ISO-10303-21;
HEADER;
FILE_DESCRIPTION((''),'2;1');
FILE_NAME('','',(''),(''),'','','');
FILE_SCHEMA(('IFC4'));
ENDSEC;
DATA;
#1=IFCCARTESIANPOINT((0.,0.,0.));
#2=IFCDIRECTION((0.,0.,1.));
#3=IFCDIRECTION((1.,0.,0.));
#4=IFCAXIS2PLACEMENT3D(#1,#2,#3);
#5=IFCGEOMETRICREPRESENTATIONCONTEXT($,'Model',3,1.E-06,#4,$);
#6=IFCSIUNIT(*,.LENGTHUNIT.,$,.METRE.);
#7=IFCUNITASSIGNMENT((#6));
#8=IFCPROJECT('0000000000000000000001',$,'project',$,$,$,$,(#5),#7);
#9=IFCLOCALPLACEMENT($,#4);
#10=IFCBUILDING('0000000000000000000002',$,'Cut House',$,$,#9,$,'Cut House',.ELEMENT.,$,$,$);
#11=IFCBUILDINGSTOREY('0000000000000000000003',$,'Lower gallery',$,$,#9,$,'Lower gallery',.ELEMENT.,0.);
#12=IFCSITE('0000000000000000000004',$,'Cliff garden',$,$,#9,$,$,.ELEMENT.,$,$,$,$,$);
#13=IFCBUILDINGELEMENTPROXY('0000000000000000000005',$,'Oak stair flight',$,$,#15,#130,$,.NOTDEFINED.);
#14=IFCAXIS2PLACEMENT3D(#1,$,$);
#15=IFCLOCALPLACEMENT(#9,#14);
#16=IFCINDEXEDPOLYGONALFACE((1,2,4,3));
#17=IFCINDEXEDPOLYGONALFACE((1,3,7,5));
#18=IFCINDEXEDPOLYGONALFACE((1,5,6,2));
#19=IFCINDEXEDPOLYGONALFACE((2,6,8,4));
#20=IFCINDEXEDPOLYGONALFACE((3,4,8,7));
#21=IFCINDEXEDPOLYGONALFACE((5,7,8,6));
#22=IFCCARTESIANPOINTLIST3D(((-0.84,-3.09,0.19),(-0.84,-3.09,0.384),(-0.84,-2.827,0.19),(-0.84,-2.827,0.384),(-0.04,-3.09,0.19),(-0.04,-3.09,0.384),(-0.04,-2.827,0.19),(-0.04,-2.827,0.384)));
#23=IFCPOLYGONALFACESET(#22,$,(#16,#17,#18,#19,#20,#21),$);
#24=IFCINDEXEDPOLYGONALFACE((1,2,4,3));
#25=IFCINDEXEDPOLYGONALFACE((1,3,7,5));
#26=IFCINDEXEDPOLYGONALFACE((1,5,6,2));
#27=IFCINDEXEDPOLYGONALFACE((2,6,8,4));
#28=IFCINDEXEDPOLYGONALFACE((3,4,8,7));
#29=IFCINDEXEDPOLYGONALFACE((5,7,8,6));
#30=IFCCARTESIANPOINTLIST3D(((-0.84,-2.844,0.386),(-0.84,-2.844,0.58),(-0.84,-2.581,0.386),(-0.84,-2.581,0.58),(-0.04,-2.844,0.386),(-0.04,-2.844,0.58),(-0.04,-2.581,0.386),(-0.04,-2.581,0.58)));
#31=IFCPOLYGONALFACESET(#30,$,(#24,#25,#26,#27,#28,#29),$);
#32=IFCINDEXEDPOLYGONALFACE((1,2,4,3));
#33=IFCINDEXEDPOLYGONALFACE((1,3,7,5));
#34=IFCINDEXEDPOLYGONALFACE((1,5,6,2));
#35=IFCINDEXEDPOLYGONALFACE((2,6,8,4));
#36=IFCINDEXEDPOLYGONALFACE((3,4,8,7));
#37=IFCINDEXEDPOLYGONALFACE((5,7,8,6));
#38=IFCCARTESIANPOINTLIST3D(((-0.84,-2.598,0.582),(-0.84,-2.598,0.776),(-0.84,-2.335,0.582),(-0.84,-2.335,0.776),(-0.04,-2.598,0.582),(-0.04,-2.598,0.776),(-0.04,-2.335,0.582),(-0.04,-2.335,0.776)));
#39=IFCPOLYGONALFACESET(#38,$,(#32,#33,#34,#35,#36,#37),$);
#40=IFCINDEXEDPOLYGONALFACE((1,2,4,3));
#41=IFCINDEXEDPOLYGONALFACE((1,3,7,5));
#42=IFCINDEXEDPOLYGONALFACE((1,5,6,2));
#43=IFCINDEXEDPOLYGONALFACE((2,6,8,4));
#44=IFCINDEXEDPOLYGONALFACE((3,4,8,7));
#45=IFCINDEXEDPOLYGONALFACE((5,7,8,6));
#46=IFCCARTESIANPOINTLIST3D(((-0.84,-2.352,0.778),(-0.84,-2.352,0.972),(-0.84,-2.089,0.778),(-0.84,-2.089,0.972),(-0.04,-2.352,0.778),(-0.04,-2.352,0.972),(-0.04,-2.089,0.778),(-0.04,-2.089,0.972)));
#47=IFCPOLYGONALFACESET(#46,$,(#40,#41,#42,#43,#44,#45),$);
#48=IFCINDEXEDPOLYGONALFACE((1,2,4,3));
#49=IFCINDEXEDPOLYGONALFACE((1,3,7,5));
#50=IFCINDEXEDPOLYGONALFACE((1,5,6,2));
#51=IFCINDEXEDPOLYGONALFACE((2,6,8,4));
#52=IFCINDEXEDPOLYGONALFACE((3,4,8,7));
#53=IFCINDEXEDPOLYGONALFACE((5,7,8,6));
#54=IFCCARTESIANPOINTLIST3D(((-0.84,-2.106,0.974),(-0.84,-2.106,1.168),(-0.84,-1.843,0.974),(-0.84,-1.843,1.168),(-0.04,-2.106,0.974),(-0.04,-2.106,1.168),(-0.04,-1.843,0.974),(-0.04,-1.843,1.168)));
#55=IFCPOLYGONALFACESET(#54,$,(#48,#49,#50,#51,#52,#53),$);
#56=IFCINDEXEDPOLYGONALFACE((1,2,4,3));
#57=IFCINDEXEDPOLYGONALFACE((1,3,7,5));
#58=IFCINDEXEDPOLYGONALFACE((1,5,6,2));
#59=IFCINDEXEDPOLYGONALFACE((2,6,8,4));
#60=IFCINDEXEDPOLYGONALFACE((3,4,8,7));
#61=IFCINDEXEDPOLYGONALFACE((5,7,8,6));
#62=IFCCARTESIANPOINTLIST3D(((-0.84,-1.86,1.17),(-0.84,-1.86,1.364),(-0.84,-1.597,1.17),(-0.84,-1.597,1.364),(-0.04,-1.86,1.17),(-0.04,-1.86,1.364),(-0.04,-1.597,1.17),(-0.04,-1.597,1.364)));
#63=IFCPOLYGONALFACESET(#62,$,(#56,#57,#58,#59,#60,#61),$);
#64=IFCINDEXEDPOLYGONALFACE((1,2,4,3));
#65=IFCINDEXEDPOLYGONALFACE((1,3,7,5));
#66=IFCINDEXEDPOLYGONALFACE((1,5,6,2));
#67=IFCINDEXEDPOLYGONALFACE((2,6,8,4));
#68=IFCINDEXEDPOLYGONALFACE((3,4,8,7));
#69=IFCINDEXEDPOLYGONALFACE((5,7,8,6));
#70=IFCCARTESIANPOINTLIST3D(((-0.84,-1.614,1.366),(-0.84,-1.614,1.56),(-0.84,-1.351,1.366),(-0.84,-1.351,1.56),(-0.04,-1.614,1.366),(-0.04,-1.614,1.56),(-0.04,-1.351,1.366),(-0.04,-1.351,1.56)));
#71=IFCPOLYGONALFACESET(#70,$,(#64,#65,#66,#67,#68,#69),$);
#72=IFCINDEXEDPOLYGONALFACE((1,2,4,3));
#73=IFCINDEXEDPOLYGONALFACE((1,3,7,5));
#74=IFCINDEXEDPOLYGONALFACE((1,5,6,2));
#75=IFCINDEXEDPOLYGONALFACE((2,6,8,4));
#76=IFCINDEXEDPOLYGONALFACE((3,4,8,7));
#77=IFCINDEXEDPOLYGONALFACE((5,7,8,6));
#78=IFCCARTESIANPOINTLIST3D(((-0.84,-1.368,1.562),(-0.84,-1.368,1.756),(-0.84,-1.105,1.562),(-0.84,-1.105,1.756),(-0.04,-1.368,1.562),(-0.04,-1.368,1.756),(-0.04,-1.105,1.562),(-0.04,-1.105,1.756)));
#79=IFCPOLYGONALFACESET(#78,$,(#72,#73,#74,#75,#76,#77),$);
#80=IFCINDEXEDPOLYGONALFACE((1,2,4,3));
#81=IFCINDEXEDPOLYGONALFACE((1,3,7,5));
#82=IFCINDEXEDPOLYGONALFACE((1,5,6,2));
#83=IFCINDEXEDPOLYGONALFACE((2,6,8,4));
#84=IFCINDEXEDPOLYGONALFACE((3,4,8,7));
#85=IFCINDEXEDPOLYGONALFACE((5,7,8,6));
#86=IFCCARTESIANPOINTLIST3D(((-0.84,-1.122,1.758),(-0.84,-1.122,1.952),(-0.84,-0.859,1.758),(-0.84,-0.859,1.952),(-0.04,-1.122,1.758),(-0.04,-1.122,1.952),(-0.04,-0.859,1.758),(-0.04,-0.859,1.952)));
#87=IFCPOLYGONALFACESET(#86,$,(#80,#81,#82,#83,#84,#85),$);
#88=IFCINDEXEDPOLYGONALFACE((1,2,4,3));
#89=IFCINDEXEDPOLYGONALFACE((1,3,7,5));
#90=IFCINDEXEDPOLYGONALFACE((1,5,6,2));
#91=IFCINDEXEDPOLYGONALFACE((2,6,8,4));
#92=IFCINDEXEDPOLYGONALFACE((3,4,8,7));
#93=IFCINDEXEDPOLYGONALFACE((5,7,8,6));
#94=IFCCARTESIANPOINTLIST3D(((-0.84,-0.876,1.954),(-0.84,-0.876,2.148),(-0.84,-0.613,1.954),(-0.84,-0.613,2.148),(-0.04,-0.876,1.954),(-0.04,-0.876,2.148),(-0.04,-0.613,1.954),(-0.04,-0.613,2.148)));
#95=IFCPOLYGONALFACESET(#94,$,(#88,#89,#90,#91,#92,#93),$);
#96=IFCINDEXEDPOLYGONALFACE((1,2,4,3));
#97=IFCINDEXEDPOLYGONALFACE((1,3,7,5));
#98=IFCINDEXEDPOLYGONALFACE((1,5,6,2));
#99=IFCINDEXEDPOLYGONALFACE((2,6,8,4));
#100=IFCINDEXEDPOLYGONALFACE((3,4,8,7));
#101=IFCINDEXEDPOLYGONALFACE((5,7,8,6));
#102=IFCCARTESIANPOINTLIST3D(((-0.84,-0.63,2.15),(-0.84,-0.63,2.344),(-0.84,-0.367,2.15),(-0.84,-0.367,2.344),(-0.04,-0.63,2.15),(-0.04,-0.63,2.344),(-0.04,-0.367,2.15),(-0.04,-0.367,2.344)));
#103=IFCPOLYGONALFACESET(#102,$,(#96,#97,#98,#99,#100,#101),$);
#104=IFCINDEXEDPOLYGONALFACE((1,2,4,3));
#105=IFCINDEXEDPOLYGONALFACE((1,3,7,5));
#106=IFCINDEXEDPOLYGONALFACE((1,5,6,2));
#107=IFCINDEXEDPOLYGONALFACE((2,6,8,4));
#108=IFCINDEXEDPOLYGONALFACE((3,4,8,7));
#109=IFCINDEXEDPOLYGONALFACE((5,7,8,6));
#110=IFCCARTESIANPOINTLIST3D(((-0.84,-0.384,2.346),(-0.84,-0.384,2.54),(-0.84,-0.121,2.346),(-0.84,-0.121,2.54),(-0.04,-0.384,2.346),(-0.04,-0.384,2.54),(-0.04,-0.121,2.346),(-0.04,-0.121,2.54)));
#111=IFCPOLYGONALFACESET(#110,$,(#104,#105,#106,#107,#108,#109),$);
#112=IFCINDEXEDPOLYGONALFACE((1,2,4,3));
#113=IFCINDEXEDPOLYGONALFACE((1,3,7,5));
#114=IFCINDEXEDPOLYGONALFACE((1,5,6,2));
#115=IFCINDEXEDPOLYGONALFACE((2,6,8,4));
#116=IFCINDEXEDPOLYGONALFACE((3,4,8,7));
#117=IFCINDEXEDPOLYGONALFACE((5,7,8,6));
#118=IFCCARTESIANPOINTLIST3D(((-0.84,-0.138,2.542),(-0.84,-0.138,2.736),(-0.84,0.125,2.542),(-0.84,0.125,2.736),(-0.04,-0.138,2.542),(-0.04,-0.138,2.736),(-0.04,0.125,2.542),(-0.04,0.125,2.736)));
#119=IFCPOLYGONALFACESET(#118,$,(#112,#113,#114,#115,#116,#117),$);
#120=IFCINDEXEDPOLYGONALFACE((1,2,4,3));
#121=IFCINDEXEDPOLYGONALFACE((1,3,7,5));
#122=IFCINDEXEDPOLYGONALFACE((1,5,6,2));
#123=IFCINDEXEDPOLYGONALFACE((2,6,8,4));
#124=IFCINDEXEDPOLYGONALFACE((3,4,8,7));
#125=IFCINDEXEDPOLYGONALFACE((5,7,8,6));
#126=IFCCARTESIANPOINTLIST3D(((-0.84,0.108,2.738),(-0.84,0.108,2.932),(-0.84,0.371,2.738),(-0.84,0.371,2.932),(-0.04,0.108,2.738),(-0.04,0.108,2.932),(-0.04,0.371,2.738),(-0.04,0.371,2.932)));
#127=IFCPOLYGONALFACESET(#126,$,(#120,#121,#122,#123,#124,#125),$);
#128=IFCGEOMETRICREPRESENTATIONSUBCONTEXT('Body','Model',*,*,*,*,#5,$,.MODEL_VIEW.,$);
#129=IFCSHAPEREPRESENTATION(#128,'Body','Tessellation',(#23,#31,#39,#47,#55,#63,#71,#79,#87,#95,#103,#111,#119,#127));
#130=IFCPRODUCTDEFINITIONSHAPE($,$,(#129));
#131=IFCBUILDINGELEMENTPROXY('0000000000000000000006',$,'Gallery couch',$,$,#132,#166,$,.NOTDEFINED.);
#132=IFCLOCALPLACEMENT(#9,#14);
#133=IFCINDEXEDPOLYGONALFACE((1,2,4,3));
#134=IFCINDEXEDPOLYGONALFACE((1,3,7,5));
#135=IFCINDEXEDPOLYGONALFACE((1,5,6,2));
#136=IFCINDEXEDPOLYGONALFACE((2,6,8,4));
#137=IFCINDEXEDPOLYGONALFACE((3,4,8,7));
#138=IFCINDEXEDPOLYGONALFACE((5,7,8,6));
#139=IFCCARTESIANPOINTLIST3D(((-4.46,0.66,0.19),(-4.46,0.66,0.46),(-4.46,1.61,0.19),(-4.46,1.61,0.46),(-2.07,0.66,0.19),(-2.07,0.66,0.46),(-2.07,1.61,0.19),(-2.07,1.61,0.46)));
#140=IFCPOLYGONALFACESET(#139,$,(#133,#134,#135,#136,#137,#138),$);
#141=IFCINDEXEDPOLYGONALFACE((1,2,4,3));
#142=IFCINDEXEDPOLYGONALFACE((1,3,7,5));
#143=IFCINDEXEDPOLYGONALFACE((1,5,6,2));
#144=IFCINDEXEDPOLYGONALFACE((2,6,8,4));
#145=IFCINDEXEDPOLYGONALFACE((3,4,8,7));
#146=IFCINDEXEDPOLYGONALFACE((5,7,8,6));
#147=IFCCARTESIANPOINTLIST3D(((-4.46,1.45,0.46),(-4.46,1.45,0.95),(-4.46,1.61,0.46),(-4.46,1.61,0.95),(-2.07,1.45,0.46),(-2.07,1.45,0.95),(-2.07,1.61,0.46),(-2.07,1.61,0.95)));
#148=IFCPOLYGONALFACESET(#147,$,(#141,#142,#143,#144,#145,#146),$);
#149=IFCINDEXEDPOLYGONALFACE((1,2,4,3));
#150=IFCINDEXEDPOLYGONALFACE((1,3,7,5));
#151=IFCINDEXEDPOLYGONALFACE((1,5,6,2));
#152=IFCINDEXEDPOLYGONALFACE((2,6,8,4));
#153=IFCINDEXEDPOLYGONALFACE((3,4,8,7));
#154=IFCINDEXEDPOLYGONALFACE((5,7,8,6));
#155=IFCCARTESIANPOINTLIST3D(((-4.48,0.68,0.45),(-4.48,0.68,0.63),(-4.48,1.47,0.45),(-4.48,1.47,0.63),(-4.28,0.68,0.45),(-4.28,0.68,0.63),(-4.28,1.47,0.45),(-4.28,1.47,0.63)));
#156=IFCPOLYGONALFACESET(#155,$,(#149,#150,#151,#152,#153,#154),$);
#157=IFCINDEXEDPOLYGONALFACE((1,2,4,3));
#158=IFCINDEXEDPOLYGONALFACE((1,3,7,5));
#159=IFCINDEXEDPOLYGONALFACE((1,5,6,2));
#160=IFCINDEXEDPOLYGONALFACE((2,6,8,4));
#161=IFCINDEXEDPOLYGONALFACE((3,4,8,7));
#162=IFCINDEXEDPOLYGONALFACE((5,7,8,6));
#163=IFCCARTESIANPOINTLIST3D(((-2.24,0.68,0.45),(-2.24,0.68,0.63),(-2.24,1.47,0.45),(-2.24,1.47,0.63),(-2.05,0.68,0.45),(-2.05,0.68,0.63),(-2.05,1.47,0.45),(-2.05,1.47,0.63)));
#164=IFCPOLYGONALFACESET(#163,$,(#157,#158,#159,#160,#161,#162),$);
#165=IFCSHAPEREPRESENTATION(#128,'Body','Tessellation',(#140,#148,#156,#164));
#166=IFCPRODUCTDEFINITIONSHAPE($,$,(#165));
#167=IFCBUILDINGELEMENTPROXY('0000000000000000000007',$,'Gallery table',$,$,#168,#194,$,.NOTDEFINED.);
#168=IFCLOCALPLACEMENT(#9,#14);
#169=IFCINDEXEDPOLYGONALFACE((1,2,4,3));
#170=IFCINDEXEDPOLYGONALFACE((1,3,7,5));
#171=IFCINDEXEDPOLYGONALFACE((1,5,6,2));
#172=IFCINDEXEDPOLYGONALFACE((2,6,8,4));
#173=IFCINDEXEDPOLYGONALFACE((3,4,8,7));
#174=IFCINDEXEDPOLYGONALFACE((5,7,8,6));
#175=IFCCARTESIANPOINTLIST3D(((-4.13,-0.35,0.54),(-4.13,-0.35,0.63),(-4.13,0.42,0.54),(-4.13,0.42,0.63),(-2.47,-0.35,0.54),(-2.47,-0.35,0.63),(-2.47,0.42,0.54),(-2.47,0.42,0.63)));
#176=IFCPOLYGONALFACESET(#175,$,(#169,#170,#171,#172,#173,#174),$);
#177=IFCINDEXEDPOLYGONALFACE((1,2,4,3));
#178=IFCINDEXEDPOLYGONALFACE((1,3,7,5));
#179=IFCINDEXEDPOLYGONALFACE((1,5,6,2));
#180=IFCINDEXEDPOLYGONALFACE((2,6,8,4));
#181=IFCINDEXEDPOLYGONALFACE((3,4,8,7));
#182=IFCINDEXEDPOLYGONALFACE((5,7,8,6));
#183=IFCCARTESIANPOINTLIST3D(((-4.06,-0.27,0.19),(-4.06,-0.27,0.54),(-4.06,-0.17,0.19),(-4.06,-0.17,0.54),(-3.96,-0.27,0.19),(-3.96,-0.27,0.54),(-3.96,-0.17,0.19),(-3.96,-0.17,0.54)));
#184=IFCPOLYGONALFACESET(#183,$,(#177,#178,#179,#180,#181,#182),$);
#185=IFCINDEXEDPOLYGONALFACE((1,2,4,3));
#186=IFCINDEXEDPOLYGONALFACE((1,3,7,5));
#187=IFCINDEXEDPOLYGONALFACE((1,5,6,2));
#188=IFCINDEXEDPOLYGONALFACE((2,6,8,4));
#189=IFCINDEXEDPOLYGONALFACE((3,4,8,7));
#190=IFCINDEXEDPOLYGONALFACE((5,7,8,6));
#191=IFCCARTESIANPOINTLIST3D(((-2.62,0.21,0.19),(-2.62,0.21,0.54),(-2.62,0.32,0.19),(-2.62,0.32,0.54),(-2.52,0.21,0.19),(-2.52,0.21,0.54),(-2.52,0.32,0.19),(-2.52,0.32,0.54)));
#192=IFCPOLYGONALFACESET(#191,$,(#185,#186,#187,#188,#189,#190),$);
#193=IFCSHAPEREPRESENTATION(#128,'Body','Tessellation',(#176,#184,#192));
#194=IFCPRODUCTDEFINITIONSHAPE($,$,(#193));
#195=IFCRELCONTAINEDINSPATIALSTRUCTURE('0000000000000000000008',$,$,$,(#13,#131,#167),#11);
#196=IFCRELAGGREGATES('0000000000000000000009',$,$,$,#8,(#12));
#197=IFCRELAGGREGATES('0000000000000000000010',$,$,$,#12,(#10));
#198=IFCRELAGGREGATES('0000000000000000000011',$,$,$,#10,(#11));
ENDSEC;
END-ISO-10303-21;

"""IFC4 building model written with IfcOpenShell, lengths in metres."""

from ifc_helpers import new_model, si_unit, frame, origin_with_axes, place, context, subcontext, project, spatial, polyline, outline, extrude, element, save


model = new_model("IFC4")

# Units and contexts
model_context = context("Model", 3, precision=1e-06, world=origin_with_axes())
body_context = subcontext(model_context, "Body", "Model", "MODEL_VIEW")
ifc_project = project(units=[si_unit("LENGTHUNIT", "METRE")], contexts=[model_context])

# Site, building, storey
placement = place(None, origin_with_axes())
site = spatial("IfcSite", under=ifc_project, at=placement, Name="Cliff garden", CompositionType="ELEMENT")
building = spatial("IfcBuilding", under=site, at=placement, Name="Cut House", LongName="Cut House", CompositionType="ELEMENT")
storey = spatial("IfcBuildingStorey", under=building, at=placement, Name="Lower gallery", LongName="Lower gallery", CompositionType="ELEMENT", Elevation=0.0)

# Building element proxies
element("IfcBuildingElementProxy", 1, at=placement, inside=storey, Name="Oak stair flight", PredefinedType="NOTDEFINED", context=body_context, shape_type="SweptSolid", body=[
    extrude(outline(polyline([(0.0, 0.0), (0.8, 0.0), (0.8, 0.263), (0.0, 0.263), (0.0, 0.0)])), frame((-0.84, -3.09, 0.19), z_axis=(0.0, 0.0, 1.0), x_axis=(1.0, 0.0, 0.0)), (0.0, 0.0, 1.0), 0.194),
    extrude(outline(polyline([(0.0, 0.0), (0.8, 0.0), (0.8, 0.263), (0.0, 0.263), (0.0, 0.0)])), frame((-0.84, -2.844, 0.386), z_axis=(0.0, 0.0, 1.0), x_axis=(1.0, 0.0, 0.0)), (0.0, 0.0, 1.0), 0.194),
    extrude(outline(polyline([(0.0, 0.0), (0.8, 0.0), (0.8, 0.263), (0.0, 0.263), (0.0, 0.0)])), frame((-0.84, -2.598, 0.582), z_axis=(0.0, 0.0, 1.0), x_axis=(1.0, 0.0, 0.0)), (0.0, 0.0, 1.0), 0.194),
    extrude(outline(polyline([(0.0, 0.0), (0.8, 0.0), (0.8, 0.263), (0.0, 0.263), (0.0, 0.0)])), frame((-0.84, -2.352, 0.778), z_axis=(0.0, 0.0, 1.0), x_axis=(1.0, 0.0, 0.0)), (0.0, 0.0, 1.0), 0.194),
    extrude(outline(polyline([(0.0, 0.0), (0.8, 0.0), (0.8, 0.263), (0.0, 0.263), (0.0, 0.0)])), frame((-0.84, -2.106, 0.974), z_axis=(0.0, 0.0, 1.0), x_axis=(1.0, 0.0, 0.0)), (0.0, 0.0, 1.0), 0.194),
    extrude(outline(polyline([(0.0, 0.0), (0.8, 0.0), (0.8, 0.263), (0.0, 0.263), (0.0, 0.0)])), frame((-0.84, -1.86, 1.17), z_axis=(0.0, 0.0, 1.0), x_axis=(1.0, 0.0, 0.0)), (0.0, 0.0, 1.0), 0.194),
    extrude(outline(polyline([(0.0, 0.0), (0.8, 0.0), (0.8, 0.263), (0.0, 0.263), (0.0, 0.0)])), frame((-0.84, -1.614, 1.366), z_axis=(0.0, 0.0, 1.0), x_axis=(1.0, 0.0, 0.0)), (0.0, 0.0, 1.0), 0.194),
    extrude(outline(polyline([(0.0, 0.0), (0.8, 0.0), (0.8, 0.263), (0.0, 0.263), (0.0, 0.0)])), frame((-0.84, -1.368, 1.562), z_axis=(0.0, 0.0, 1.0), x_axis=(1.0, 0.0, 0.0)), (0.0, 0.0, 1.0), 0.194),
    extrude(outline(polyline([(0.0, 0.0), (0.8, 0.0), (0.8, 0.263), (0.0, 0.263), (0.0, 0.0)])), frame((-0.84, -1.122, 1.758), z_axis=(0.0, 0.0, 1.0), x_axis=(1.0, 0.0, 0.0)), (0.0, 0.0, 1.0), 0.194),
    extrude(outline(polyline([(0.0, 0.0), (0.8, 0.0), (0.8, 0.263), (0.0, 0.263), (0.0, 0.0)])), frame((-0.84, -0.876, 1.954), z_axis=(0.0, 0.0, 1.0), x_axis=(1.0, 0.0, 0.0)), (0.0, 0.0, 1.0), 0.194),
    extrude(outline(polyline([(0.0, 0.0), (0.8, 0.0), (0.8, 0.263), (0.0, 0.263), (0.0, 0.0)])), frame((-0.84, -0.63, 2.15), z_axis=(0.0, 0.0, 1.0), x_axis=(1.0, 0.0, 0.0)), (0.0, 0.0, 1.0), 0.194),
    extrude(outline(polyline([(0.0, 0.0), (0.8, 0.0), (0.8, 0.263), (0.0, 0.263), (0.0, 0.0)])), frame((-0.84, -0.384, 2.346), z_axis=(0.0, 0.0, 1.0), x_axis=(1.0, 0.0, 0.0)), (0.0, 0.0, 1.0), 0.194),
    extrude(outline(polyline([(0.0, 0.0), (0.8, 0.0), (0.8, 0.263), (0.0, 0.263), (0.0, 0.0)])), frame((-0.84, -0.138, 2.542), z_axis=(0.0, 0.0, 1.0), x_axis=(1.0, 0.0, 0.0)), (0.0, 0.0, 1.0), 0.194),
    extrude(outline(polyline([(0.0, 0.0), (0.8, 0.0), (0.8, 0.263), (0.0, 0.263), (0.0, 0.0)])), frame((-0.84, 0.108, 2.738), z_axis=(0.0, 0.0, 1.0), x_axis=(1.0, 0.0, 0.0)), (0.0, 0.0, 1.0), 0.194),
])
element("IfcBuildingElementProxy", 2, at=placement, inside=storey, Name="Gallery couch", PredefinedType="NOTDEFINED", context=body_context, shape_type="SweptSolid", body=[
    extrude(outline(polyline([(0.0, 0.0), (2.39, 0.0), (2.39, 0.95), (0.0, 0.95), (0.0, 0.0)])), frame((-4.46, 0.66, 0.19), z_axis=(0.0, 0.0, 1.0), x_axis=(1.0, 0.0, 0.0)), (0.0, 0.0, 1.0), 0.27),
    extrude(outline(polyline([(0.0, 0.0), (2.39, 0.0), (2.39, 0.16), (0.0, 0.16), (0.0, 0.0)])), frame((-4.46, 1.45, 0.46), z_axis=(0.0, 0.0, 1.0), x_axis=(1.0, 0.0, 0.0)), (0.0, 0.0, 1.0), 0.49),
    extrude(outline(polyline([(0.0, 0.0), (0.2, 0.0), (0.2, 0.79), (0.0, 0.79), (0.0, 0.0)])), frame((-4.48, 0.68, 0.45), z_axis=(0.0, 0.0, 1.0), x_axis=(1.0, 0.0, 0.0)), (0.0, 0.0, 1.0), 0.18),
    extrude(outline(polyline([(0.0, 0.0), (0.19, 0.0), (0.19, 0.79), (0.0, 0.79), (0.0, 0.0)])), frame((-2.24, 0.68, 0.45), z_axis=(0.0, 0.0, 1.0), x_axis=(1.0, 0.0, 0.0)), (0.0, 0.0, 1.0), 0.18),
])
element("IfcBuildingElementProxy", 3, at=placement, inside=storey, Name="Gallery table", PredefinedType="NOTDEFINED", context=body_context, shape_type="SweptSolid", body=[
    extrude(outline(polyline([(0.0, 0.0), (1.66, 0.0), (1.66, 0.77), (0.0, 0.77), (0.0, 0.0)])), frame((-4.13, -0.35, 0.54), z_axis=(0.0, 0.0, 1.0), x_axis=(1.0, 0.0, 0.0)), (0.0, 0.0, 1.0), 0.09),
    extrude(outline(polyline([(0.0, 0.0), (0.1, 0.0), (0.1, 0.1), (0.0, 0.1), (0.0, 0.0)])), frame((-4.06, -0.27, 0.19), z_axis=(0.0, 0.0, 1.0), x_axis=(1.0, 0.0, 0.0)), (0.0, 0.0, 1.0), 0.35),
    extrude(outline(polyline([(0.0, 0.0), (0.1, 0.0), (0.1, 0.11), (0.0, 0.11), (0.0, 0.0)])), frame((-2.62, 0.21, 0.19), z_axis=(0.0, 0.0, 1.0), x_axis=(1.0, 0.0, 0.0)), (0.0, 0.0, 1.0), 0.35),
])

save(model, "model.ifc")
